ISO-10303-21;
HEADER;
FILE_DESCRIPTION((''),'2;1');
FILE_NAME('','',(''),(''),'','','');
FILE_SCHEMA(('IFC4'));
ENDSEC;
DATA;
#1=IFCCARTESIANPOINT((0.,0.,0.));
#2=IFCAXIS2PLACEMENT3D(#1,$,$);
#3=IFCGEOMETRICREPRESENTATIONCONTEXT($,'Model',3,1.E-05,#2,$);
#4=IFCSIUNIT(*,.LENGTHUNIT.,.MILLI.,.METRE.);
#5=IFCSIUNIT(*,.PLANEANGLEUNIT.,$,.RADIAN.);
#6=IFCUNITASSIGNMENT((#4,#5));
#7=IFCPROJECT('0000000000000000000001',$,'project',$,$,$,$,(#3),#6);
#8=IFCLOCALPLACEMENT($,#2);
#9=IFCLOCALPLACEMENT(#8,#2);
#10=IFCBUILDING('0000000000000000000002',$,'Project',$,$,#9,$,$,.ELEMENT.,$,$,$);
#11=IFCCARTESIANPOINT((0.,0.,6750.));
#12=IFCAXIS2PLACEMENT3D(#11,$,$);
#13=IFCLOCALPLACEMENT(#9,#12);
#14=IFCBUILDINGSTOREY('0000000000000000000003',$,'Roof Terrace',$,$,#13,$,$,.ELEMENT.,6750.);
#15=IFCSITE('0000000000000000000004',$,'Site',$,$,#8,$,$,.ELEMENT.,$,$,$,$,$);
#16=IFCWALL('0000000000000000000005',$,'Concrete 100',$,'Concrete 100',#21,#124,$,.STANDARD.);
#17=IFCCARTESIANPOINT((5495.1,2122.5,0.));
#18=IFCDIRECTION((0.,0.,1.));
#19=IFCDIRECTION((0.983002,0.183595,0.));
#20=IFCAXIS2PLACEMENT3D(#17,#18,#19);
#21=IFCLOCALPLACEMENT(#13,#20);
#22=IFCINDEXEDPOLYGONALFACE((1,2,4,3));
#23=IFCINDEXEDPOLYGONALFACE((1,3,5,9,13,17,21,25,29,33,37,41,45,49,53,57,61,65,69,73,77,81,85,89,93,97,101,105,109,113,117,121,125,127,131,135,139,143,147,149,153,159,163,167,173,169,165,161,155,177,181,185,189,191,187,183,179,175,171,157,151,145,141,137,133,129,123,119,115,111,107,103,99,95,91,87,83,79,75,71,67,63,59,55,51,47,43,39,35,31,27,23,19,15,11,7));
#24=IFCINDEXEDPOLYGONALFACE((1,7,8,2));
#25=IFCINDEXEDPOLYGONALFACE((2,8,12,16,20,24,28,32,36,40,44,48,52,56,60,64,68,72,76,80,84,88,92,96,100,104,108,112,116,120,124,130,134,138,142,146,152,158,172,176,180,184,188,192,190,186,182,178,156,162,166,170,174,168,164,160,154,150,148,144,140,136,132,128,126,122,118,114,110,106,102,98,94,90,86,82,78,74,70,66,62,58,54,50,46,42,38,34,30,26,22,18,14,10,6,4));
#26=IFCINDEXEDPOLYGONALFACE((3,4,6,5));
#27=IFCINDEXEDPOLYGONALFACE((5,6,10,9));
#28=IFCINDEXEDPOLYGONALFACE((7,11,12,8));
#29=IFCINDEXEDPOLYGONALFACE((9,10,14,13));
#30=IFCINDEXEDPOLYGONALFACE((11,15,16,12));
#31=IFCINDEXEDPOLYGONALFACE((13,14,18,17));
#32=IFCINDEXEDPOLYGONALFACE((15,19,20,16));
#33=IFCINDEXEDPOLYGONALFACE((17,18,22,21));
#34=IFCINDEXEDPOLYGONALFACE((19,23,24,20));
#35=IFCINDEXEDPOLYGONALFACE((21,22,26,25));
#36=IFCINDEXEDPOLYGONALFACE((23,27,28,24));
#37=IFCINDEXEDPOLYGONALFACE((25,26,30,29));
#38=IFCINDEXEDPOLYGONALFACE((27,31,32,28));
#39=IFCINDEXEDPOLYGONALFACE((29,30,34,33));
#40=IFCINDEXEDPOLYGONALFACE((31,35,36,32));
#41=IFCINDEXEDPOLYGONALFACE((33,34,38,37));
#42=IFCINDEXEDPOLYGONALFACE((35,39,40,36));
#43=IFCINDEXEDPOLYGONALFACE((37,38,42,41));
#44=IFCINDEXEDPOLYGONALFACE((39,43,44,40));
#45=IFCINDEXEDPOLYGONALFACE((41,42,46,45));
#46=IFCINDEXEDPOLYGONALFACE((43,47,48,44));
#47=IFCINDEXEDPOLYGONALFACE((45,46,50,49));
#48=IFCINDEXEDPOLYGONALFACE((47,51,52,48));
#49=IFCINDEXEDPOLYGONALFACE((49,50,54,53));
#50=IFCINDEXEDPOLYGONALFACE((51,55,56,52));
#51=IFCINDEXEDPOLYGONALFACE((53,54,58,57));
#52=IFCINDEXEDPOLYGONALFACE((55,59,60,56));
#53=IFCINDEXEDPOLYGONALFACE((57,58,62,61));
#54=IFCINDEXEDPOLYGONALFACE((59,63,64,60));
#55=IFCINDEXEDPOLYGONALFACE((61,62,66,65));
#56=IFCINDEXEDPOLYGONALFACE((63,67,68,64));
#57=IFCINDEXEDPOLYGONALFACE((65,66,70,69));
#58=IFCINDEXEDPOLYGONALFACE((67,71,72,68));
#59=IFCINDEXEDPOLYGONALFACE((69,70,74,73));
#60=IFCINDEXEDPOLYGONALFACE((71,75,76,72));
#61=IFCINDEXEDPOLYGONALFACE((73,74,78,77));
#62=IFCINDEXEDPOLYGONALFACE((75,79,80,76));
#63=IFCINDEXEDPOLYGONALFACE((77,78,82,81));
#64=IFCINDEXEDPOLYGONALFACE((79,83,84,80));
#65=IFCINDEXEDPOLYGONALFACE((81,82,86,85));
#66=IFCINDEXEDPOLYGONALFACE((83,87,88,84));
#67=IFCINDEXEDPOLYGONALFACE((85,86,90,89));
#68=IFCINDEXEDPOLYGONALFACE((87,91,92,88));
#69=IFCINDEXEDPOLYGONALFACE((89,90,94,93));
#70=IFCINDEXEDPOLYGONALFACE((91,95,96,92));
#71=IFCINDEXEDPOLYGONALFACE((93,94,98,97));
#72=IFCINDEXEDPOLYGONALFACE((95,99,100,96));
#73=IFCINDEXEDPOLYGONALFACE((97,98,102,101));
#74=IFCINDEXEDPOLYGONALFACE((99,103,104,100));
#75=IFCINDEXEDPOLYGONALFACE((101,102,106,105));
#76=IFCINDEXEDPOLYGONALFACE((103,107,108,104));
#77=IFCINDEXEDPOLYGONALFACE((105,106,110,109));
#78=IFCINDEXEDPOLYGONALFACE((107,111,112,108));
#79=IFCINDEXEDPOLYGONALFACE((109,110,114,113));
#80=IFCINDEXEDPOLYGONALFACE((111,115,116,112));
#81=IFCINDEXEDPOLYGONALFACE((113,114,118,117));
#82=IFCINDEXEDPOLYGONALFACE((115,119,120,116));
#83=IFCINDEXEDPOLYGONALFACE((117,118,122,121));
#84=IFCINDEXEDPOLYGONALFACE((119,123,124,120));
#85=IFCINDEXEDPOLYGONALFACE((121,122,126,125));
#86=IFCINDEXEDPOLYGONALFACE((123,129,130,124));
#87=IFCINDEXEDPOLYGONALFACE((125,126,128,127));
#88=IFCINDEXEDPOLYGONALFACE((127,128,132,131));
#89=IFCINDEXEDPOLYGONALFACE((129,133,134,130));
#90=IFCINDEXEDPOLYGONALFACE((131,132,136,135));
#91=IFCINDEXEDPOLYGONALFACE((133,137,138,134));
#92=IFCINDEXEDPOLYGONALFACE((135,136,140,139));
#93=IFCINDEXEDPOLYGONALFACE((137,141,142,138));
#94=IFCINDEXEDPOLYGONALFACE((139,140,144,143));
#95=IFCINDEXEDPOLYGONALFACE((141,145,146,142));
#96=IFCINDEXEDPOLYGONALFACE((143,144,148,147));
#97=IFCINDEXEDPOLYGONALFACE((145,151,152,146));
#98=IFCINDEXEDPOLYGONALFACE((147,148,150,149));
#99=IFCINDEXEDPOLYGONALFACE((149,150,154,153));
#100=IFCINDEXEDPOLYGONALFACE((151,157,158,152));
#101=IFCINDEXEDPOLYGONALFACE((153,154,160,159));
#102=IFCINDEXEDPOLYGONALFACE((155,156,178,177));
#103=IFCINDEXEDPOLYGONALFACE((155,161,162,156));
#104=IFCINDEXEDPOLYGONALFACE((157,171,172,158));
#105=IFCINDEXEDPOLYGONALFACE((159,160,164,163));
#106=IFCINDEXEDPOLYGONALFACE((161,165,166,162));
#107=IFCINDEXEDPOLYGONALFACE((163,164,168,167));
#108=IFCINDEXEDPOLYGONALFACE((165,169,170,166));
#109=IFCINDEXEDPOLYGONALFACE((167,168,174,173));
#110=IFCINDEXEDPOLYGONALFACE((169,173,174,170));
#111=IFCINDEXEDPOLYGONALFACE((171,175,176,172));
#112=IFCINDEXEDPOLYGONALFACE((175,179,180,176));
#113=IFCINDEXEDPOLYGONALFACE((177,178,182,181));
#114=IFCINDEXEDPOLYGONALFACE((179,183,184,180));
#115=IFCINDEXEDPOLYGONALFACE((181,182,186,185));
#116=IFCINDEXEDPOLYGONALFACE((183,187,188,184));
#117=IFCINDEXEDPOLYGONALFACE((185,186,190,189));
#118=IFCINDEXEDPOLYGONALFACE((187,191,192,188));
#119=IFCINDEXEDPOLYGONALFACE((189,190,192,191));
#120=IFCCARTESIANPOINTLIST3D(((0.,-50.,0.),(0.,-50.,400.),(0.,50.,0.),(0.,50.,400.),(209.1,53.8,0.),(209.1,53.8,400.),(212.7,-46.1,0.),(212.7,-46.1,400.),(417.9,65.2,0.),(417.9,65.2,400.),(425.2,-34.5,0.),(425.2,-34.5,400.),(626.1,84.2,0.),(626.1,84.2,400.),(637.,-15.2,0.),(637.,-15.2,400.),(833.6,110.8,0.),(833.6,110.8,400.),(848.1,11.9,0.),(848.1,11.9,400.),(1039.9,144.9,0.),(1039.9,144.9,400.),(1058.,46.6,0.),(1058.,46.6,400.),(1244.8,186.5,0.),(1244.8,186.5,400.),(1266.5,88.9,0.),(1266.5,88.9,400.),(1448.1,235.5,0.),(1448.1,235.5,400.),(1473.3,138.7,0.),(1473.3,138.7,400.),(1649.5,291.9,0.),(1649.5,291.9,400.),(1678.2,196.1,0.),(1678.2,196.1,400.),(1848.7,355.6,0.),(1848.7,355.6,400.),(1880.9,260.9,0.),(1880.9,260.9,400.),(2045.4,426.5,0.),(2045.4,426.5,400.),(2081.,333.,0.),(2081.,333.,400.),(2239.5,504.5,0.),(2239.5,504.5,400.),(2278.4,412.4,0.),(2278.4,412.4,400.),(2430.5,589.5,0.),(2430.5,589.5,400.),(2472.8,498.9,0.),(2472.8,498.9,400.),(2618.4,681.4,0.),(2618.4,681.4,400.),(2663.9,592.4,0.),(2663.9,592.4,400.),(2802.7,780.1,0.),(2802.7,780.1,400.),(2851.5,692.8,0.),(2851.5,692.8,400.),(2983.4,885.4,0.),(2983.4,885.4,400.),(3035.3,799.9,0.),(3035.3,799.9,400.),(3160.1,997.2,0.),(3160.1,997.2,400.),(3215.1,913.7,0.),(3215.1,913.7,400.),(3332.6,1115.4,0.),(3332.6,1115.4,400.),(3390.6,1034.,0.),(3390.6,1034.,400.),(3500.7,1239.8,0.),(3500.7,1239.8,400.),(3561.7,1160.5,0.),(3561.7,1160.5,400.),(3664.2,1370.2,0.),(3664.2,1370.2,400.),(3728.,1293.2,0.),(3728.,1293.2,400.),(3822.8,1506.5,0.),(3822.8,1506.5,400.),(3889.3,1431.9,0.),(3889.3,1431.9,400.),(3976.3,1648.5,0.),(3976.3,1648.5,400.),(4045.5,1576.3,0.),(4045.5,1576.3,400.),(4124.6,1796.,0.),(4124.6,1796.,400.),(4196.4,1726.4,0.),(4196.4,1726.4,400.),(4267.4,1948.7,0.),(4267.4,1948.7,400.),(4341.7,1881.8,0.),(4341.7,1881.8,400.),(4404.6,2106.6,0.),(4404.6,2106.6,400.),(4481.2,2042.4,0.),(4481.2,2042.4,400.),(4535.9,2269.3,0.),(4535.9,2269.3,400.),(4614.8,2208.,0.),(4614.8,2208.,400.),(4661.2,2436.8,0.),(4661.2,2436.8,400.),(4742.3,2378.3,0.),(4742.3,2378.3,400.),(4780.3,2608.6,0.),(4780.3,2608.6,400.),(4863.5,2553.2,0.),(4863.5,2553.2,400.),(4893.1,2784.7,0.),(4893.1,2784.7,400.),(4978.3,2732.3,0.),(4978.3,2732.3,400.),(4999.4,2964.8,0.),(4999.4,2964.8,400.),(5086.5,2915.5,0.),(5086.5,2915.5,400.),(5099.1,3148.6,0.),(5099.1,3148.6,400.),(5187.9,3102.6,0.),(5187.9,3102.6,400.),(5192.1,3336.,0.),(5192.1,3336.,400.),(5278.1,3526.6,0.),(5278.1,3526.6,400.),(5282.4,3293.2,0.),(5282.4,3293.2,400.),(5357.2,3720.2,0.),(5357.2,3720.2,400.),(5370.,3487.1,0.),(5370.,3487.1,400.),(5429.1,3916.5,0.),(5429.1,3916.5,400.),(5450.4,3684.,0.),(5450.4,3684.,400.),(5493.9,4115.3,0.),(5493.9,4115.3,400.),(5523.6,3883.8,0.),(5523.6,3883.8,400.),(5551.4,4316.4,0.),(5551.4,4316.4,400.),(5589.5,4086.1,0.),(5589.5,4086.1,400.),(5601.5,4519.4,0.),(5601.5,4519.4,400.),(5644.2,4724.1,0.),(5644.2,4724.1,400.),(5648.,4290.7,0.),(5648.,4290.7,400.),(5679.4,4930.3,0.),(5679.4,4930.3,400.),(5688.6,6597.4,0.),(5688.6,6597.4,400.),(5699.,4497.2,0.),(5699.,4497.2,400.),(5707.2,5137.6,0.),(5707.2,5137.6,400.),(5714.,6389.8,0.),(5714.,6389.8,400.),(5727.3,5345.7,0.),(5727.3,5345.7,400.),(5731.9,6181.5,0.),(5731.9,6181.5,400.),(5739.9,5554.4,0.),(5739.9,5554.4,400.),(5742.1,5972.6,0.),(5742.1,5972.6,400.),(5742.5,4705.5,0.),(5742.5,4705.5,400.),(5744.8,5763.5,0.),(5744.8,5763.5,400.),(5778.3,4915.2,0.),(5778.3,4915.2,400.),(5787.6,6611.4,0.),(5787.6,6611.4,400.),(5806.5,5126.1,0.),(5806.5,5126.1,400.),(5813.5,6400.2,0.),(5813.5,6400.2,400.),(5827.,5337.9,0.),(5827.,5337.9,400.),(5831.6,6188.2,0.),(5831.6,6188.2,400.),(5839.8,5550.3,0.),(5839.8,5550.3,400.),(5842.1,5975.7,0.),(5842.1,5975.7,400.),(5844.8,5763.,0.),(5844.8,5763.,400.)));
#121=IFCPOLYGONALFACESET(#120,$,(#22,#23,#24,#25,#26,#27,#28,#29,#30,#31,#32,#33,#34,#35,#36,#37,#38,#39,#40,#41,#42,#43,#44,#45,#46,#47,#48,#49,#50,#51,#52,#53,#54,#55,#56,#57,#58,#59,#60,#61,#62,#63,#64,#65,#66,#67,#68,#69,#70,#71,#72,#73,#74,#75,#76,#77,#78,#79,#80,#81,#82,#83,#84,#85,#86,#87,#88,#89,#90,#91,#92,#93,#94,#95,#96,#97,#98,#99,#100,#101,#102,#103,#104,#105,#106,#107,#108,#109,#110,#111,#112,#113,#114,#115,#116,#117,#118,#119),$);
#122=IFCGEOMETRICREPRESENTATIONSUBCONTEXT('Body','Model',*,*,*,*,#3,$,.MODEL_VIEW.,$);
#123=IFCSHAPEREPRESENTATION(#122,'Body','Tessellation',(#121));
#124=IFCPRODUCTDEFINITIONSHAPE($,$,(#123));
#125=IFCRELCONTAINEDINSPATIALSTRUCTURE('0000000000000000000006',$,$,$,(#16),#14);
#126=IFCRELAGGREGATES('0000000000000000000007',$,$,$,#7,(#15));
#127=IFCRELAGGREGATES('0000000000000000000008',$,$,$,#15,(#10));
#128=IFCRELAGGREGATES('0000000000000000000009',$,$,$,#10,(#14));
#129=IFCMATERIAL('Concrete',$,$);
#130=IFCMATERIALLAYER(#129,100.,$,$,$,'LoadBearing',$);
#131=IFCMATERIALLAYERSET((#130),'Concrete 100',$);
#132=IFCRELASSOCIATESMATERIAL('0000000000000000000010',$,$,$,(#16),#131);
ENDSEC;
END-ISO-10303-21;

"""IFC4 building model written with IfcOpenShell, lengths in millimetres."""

from ifc_helpers import new_model, si_unit, frame, origin, place, context, subcontext, project, spatial, polyline, outline, extrude, material, layer, layer_set, layer_usage, element, save


model = new_model("IFC4")

# Units and contexts
model_context = context("Model", 3, precision=1e-05, world=origin())
body_context = subcontext(model_context, "Body", "Model", "MODEL_VIEW")
ifc_project = project(units=[si_unit("LENGTHUNIT", "METRE", prefix="MILLI"), si_unit("PLANEANGLEUNIT", "RADIAN")], contexts=[model_context])

# Site, building, storey
site_placement = place(None, origin())
site = spatial("IfcSite", under=ifc_project, at=site_placement, Name="Site", CompositionType="ELEMENT")
building_placement = place(site_placement, origin())
building = spatial("IfcBuilding", under=site, at=building_placement, Name="Project", CompositionType="ELEMENT")
storey_placement = place(building_placement, frame((0.0, 0.0, 6750.0)))
storey = spatial("IfcBuildingStorey", under=building, at=storey_placement, Name="Roof Terrace", CompositionType="ELEMENT", Elevation=6750.0)

# Shared definitions
ifc_material = material(Name="Concrete")

# Wall
ifc_layer_1 = layer(ifc_material, 100.0, Category="LoadBearing")
ifc_layer_set_1 = layer_set([ifc_layer_1], Name="Concrete 100")
ifc_layer_usage_1 = layer_usage(ifc_layer_set_1, "AXIS2", "NEGATIVE", 50.0)
wall_1_placement = place(storey_placement, frame((5495.1, 2122.5, 0.0), z_axis=(0.0, 0.0, 1.0), x_axis=(0.983002, 0.183595, 0.0)))
element("IfcWall", 1, at=wall_1_placement, inside=storey, material=ifc_layer_usage_1, Name="Concrete 100", ObjectType="Concrete 100", PredefinedType="STANDARD", context=body_context, shape_type="SweptSolid", body=[
    extrude(outline(polyline([(0.0, -50.0), (0.0, 50.0), (209.1, 53.8), (417.9, 65.2), (626.1, 84.2), (833.6, 110.8), (1039.9, 144.9), (1244.8, 186.5), (1448.1, 235.5), (1649.5, 291.9), (1848.7, 355.6), (2045.4, 426.5), (2239.5, 504.5), (2430.5, 589.5), (2618.4, 681.4), (2802.7, 780.1), (2983.4, 885.4), (3160.1, 997.2), (3332.6, 1115.4), (3500.7, 1239.8), (3664.2, 1370.2), (3822.8, 1506.5), (3976.3, 1648.5), (4124.6, 1796.0), (4267.4, 1948.7), (4404.6, 2106.6), (4535.9, 2269.3), (4661.2, 2436.8), (4780.3, 2608.6), (4893.1, 2784.7), (4999.4, 2964.8), (5099.1, 3148.6), (5192.1, 3336.0), (5278.1, 3526.6), (5357.2, 3720.2), (5429.1, 3916.5), (5493.9, 4115.3), (5551.4, 4316.4), (5601.5, 4519.4), (5644.2, 4724.1), (5679.4, 4930.3), (5707.2, 5137.6), (5727.3, 5345.7), (5739.9, 5554.4), (5744.8, 5763.5), (5742.1, 5972.6), (5731.9, 6181.5), (5714.0, 6389.8), (5688.6, 6597.4), (5787.6, 6611.4), (5813.5, 6400.2), (5831.6, 6188.2), (5842.1, 5975.7), (5844.8, 5763.0), (5839.8, 5550.3), (5827.0, 5337.9), (5806.5, 5126.1), (5778.3, 4915.2), (5742.5, 4705.5), (5699.0, 4497.2), (5648.0, 4290.7), (5589.5, 4086.1), (5523.6, 3883.8), (5450.4, 3684.0), (5370.0, 3487.1), (5282.4, 3293.2), (5187.9, 3102.6), (5086.5, 2915.5), (4978.3, 2732.3), (4863.5, 2553.2), (4742.3, 2378.3), (4614.8, 2208.0), (4481.2, 2042.4), (4341.7, 1881.8), (4196.4, 1726.4), (4045.5, 1576.3), (3889.3, 1431.9), (3728.0, 1293.2), (3561.7, 1160.5), (3390.6, 1034.0), (3215.1, 913.7), (3035.3, 799.9), (2851.5, 692.8), (2663.9, 592.4), (2472.8, 498.9), (2278.4, 412.4), (2081.0, 333.0), (1880.9, 260.9), (1678.2, 196.1), (1473.3, 138.7), (1266.5, 88.9), (1058.0, 46.6), (848.1, 11.9), (637.0, -15.2), (425.2, -34.5), (212.7, -46.1), (0.0, -50.0)])), origin(), (0.0, 0.0, 1.0), 400.0),
])

save(model, "model.ifc")
